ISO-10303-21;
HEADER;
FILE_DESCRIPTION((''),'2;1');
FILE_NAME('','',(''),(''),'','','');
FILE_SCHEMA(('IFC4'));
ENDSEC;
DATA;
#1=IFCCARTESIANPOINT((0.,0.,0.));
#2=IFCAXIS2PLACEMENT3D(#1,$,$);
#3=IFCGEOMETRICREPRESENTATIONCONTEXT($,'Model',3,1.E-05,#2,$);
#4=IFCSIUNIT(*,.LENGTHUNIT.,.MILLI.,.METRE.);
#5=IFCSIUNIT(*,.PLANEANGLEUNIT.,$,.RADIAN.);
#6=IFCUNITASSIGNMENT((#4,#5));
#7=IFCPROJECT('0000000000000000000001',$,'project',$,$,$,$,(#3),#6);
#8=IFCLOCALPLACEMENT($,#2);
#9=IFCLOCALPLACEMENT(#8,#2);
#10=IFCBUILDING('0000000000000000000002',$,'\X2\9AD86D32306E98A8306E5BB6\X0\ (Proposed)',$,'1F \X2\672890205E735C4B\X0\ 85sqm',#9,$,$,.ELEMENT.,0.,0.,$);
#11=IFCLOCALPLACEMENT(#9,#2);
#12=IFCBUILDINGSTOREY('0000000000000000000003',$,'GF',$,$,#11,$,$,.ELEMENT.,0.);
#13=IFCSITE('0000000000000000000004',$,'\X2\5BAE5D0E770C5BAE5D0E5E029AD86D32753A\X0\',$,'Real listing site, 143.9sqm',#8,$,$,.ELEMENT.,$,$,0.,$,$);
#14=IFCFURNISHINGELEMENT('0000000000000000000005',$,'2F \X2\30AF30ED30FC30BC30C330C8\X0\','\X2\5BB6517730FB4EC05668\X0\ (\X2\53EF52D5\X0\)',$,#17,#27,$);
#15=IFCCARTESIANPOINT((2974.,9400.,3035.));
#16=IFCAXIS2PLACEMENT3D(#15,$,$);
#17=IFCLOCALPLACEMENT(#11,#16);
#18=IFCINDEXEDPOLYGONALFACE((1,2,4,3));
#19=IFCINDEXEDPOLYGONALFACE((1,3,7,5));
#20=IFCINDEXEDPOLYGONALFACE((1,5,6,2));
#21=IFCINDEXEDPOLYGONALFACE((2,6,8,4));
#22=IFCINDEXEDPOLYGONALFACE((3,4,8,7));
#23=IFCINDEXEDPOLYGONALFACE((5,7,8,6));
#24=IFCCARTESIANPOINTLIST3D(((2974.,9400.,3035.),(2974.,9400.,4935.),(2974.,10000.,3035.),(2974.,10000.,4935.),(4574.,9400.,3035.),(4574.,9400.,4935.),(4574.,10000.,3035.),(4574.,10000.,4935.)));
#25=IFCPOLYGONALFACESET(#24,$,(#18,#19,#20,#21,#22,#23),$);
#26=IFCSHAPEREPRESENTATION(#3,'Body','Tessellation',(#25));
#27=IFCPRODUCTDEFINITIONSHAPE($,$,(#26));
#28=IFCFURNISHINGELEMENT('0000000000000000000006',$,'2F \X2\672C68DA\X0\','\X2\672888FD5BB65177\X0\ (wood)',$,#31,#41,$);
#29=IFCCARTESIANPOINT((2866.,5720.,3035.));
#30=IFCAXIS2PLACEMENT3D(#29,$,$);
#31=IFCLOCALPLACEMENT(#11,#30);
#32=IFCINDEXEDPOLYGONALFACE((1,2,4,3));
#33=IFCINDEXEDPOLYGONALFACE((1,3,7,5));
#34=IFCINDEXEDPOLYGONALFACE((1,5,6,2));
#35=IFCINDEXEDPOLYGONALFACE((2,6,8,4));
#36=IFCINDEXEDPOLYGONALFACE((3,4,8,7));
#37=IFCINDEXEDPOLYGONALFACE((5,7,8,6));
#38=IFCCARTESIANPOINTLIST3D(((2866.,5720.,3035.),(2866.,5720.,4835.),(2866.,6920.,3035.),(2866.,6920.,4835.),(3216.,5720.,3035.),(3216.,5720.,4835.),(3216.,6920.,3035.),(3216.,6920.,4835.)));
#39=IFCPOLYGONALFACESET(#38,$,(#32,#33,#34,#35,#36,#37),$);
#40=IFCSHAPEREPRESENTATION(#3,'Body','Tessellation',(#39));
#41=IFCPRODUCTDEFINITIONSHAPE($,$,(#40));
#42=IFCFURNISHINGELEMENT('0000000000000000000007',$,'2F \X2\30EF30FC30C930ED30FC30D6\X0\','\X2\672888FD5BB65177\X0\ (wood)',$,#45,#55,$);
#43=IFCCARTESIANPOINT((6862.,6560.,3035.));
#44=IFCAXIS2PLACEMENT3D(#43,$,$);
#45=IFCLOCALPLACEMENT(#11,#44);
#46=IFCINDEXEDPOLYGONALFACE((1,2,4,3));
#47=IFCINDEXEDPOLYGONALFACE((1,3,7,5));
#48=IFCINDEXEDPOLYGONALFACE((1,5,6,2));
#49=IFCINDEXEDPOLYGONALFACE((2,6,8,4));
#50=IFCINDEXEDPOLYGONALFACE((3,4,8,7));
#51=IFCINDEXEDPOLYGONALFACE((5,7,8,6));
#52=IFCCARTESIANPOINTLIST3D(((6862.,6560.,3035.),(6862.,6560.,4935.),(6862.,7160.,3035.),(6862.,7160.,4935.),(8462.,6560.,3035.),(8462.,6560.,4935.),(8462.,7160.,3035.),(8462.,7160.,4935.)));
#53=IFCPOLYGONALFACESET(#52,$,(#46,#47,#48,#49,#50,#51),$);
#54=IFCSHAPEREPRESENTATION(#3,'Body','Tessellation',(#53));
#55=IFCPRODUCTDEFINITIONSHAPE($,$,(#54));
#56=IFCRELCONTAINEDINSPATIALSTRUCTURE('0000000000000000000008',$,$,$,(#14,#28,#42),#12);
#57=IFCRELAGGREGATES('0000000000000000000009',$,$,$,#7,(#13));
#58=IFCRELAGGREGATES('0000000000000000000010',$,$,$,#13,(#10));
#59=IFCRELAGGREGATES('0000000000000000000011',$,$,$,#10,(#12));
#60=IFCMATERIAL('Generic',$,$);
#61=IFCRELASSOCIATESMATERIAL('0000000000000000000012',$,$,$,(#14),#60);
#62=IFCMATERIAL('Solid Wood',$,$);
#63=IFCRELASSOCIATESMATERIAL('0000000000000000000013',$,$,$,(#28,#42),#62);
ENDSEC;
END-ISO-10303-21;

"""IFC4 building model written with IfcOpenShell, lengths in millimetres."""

from ifc_helpers import new_model, si_unit, frame, frame_2d, origin, place, context, project, spatial, rectangle, extrude, material, element, save


model = new_model("IFC4")

# Units and contexts
model_context = context("Model", 3, precision=1e-05, world=origin())
ifc_project = project(units=[si_unit("LENGTHUNIT", "METRE", prefix="MILLI"), si_unit("PLANEANGLEUNIT", "RADIAN")], contexts=[model_context])

# Site, building, storey
site_placement = place(None, origin())
site = spatial("IfcSite", under=ifc_project, at=site_placement, Name="宮崎県宮崎市高洲町", ObjectType="Real listing site, 143.9sqm", CompositionType="ELEMENT", RefElevation=0.0)
building_placement = place(site_placement, origin())
building = spatial("IfcBuilding", under=site, at=building_placement, Name="高洲の風の家 (Proposed)", ObjectType="1F 木造平屋 85sqm", CompositionType="ELEMENT", ElevationOfRefHeight=0.0, ElevationOfTerrain=0.0)
storey_placement = place(building_placement, origin())
storey = spatial("IfcBuildingStorey", under=building, at=storey_placement, Name="GF", CompositionType="ELEMENT", Elevation=0.0)

# Shared definitions
ifc_material_1 = material(Name="Solid Wood")

# Shared definitions
ifc_material_2 = material(Name="Generic")

# Furnishing elements
furnishing_1_placement = place(storey_placement, frame((2974.0, 9400.0, 3035.0)))
element("IfcFurnishingElement", 1, at=furnishing_1_placement, inside=storey, material=ifc_material_2, Name="2F クローゼット", Description="家具・什器 (可動)", context=model_context, shape_type="SweptSolid", body=[
    extrude(rectangle(XDim=1600.0, YDim=600.0, at=frame_2d((800.0, 300.0))), frame((2974.0, 9400.0, 3035.0)), (0.0, 0.0, 1.0), 1900.0),
])
furnishing_2_placement = place(storey_placement, frame((2866.0, 5720.0, 3035.0)))
element("IfcFurnishingElement", 2, at=furnishing_2_placement, inside=storey, material=ifc_material_1, Name="2F 本棚", Description="木製家具 (wood)", context=model_context, shape_type="SweptSolid", body=[
    extrude(rectangle(XDim=350.0, YDim=1200.0, at=frame_2d((175.0, 600.0))), frame((2866.0, 5720.0, 3035.0)), (0.0, 0.0, 1.0), 1800.0),
])
furnishing_3_placement = place(storey_placement, frame((6862.0, 6560.0, 3035.0)))
element("IfcFurnishingElement", 3, at=furnishing_3_placement, inside=storey, material=ifc_material_1, Name="2F ワードローブ", Description="木製家具 (wood)", context=model_context, shape_type="SweptSolid", body=[
    extrude(rectangle(XDim=1600.0, YDim=600.0, at=frame_2d((800.0, 300.0))), frame((6862.0, 6560.0, 3035.0)), (0.0, 0.0, 1.0), 1900.0),
])

save(model, "model.ifc")
